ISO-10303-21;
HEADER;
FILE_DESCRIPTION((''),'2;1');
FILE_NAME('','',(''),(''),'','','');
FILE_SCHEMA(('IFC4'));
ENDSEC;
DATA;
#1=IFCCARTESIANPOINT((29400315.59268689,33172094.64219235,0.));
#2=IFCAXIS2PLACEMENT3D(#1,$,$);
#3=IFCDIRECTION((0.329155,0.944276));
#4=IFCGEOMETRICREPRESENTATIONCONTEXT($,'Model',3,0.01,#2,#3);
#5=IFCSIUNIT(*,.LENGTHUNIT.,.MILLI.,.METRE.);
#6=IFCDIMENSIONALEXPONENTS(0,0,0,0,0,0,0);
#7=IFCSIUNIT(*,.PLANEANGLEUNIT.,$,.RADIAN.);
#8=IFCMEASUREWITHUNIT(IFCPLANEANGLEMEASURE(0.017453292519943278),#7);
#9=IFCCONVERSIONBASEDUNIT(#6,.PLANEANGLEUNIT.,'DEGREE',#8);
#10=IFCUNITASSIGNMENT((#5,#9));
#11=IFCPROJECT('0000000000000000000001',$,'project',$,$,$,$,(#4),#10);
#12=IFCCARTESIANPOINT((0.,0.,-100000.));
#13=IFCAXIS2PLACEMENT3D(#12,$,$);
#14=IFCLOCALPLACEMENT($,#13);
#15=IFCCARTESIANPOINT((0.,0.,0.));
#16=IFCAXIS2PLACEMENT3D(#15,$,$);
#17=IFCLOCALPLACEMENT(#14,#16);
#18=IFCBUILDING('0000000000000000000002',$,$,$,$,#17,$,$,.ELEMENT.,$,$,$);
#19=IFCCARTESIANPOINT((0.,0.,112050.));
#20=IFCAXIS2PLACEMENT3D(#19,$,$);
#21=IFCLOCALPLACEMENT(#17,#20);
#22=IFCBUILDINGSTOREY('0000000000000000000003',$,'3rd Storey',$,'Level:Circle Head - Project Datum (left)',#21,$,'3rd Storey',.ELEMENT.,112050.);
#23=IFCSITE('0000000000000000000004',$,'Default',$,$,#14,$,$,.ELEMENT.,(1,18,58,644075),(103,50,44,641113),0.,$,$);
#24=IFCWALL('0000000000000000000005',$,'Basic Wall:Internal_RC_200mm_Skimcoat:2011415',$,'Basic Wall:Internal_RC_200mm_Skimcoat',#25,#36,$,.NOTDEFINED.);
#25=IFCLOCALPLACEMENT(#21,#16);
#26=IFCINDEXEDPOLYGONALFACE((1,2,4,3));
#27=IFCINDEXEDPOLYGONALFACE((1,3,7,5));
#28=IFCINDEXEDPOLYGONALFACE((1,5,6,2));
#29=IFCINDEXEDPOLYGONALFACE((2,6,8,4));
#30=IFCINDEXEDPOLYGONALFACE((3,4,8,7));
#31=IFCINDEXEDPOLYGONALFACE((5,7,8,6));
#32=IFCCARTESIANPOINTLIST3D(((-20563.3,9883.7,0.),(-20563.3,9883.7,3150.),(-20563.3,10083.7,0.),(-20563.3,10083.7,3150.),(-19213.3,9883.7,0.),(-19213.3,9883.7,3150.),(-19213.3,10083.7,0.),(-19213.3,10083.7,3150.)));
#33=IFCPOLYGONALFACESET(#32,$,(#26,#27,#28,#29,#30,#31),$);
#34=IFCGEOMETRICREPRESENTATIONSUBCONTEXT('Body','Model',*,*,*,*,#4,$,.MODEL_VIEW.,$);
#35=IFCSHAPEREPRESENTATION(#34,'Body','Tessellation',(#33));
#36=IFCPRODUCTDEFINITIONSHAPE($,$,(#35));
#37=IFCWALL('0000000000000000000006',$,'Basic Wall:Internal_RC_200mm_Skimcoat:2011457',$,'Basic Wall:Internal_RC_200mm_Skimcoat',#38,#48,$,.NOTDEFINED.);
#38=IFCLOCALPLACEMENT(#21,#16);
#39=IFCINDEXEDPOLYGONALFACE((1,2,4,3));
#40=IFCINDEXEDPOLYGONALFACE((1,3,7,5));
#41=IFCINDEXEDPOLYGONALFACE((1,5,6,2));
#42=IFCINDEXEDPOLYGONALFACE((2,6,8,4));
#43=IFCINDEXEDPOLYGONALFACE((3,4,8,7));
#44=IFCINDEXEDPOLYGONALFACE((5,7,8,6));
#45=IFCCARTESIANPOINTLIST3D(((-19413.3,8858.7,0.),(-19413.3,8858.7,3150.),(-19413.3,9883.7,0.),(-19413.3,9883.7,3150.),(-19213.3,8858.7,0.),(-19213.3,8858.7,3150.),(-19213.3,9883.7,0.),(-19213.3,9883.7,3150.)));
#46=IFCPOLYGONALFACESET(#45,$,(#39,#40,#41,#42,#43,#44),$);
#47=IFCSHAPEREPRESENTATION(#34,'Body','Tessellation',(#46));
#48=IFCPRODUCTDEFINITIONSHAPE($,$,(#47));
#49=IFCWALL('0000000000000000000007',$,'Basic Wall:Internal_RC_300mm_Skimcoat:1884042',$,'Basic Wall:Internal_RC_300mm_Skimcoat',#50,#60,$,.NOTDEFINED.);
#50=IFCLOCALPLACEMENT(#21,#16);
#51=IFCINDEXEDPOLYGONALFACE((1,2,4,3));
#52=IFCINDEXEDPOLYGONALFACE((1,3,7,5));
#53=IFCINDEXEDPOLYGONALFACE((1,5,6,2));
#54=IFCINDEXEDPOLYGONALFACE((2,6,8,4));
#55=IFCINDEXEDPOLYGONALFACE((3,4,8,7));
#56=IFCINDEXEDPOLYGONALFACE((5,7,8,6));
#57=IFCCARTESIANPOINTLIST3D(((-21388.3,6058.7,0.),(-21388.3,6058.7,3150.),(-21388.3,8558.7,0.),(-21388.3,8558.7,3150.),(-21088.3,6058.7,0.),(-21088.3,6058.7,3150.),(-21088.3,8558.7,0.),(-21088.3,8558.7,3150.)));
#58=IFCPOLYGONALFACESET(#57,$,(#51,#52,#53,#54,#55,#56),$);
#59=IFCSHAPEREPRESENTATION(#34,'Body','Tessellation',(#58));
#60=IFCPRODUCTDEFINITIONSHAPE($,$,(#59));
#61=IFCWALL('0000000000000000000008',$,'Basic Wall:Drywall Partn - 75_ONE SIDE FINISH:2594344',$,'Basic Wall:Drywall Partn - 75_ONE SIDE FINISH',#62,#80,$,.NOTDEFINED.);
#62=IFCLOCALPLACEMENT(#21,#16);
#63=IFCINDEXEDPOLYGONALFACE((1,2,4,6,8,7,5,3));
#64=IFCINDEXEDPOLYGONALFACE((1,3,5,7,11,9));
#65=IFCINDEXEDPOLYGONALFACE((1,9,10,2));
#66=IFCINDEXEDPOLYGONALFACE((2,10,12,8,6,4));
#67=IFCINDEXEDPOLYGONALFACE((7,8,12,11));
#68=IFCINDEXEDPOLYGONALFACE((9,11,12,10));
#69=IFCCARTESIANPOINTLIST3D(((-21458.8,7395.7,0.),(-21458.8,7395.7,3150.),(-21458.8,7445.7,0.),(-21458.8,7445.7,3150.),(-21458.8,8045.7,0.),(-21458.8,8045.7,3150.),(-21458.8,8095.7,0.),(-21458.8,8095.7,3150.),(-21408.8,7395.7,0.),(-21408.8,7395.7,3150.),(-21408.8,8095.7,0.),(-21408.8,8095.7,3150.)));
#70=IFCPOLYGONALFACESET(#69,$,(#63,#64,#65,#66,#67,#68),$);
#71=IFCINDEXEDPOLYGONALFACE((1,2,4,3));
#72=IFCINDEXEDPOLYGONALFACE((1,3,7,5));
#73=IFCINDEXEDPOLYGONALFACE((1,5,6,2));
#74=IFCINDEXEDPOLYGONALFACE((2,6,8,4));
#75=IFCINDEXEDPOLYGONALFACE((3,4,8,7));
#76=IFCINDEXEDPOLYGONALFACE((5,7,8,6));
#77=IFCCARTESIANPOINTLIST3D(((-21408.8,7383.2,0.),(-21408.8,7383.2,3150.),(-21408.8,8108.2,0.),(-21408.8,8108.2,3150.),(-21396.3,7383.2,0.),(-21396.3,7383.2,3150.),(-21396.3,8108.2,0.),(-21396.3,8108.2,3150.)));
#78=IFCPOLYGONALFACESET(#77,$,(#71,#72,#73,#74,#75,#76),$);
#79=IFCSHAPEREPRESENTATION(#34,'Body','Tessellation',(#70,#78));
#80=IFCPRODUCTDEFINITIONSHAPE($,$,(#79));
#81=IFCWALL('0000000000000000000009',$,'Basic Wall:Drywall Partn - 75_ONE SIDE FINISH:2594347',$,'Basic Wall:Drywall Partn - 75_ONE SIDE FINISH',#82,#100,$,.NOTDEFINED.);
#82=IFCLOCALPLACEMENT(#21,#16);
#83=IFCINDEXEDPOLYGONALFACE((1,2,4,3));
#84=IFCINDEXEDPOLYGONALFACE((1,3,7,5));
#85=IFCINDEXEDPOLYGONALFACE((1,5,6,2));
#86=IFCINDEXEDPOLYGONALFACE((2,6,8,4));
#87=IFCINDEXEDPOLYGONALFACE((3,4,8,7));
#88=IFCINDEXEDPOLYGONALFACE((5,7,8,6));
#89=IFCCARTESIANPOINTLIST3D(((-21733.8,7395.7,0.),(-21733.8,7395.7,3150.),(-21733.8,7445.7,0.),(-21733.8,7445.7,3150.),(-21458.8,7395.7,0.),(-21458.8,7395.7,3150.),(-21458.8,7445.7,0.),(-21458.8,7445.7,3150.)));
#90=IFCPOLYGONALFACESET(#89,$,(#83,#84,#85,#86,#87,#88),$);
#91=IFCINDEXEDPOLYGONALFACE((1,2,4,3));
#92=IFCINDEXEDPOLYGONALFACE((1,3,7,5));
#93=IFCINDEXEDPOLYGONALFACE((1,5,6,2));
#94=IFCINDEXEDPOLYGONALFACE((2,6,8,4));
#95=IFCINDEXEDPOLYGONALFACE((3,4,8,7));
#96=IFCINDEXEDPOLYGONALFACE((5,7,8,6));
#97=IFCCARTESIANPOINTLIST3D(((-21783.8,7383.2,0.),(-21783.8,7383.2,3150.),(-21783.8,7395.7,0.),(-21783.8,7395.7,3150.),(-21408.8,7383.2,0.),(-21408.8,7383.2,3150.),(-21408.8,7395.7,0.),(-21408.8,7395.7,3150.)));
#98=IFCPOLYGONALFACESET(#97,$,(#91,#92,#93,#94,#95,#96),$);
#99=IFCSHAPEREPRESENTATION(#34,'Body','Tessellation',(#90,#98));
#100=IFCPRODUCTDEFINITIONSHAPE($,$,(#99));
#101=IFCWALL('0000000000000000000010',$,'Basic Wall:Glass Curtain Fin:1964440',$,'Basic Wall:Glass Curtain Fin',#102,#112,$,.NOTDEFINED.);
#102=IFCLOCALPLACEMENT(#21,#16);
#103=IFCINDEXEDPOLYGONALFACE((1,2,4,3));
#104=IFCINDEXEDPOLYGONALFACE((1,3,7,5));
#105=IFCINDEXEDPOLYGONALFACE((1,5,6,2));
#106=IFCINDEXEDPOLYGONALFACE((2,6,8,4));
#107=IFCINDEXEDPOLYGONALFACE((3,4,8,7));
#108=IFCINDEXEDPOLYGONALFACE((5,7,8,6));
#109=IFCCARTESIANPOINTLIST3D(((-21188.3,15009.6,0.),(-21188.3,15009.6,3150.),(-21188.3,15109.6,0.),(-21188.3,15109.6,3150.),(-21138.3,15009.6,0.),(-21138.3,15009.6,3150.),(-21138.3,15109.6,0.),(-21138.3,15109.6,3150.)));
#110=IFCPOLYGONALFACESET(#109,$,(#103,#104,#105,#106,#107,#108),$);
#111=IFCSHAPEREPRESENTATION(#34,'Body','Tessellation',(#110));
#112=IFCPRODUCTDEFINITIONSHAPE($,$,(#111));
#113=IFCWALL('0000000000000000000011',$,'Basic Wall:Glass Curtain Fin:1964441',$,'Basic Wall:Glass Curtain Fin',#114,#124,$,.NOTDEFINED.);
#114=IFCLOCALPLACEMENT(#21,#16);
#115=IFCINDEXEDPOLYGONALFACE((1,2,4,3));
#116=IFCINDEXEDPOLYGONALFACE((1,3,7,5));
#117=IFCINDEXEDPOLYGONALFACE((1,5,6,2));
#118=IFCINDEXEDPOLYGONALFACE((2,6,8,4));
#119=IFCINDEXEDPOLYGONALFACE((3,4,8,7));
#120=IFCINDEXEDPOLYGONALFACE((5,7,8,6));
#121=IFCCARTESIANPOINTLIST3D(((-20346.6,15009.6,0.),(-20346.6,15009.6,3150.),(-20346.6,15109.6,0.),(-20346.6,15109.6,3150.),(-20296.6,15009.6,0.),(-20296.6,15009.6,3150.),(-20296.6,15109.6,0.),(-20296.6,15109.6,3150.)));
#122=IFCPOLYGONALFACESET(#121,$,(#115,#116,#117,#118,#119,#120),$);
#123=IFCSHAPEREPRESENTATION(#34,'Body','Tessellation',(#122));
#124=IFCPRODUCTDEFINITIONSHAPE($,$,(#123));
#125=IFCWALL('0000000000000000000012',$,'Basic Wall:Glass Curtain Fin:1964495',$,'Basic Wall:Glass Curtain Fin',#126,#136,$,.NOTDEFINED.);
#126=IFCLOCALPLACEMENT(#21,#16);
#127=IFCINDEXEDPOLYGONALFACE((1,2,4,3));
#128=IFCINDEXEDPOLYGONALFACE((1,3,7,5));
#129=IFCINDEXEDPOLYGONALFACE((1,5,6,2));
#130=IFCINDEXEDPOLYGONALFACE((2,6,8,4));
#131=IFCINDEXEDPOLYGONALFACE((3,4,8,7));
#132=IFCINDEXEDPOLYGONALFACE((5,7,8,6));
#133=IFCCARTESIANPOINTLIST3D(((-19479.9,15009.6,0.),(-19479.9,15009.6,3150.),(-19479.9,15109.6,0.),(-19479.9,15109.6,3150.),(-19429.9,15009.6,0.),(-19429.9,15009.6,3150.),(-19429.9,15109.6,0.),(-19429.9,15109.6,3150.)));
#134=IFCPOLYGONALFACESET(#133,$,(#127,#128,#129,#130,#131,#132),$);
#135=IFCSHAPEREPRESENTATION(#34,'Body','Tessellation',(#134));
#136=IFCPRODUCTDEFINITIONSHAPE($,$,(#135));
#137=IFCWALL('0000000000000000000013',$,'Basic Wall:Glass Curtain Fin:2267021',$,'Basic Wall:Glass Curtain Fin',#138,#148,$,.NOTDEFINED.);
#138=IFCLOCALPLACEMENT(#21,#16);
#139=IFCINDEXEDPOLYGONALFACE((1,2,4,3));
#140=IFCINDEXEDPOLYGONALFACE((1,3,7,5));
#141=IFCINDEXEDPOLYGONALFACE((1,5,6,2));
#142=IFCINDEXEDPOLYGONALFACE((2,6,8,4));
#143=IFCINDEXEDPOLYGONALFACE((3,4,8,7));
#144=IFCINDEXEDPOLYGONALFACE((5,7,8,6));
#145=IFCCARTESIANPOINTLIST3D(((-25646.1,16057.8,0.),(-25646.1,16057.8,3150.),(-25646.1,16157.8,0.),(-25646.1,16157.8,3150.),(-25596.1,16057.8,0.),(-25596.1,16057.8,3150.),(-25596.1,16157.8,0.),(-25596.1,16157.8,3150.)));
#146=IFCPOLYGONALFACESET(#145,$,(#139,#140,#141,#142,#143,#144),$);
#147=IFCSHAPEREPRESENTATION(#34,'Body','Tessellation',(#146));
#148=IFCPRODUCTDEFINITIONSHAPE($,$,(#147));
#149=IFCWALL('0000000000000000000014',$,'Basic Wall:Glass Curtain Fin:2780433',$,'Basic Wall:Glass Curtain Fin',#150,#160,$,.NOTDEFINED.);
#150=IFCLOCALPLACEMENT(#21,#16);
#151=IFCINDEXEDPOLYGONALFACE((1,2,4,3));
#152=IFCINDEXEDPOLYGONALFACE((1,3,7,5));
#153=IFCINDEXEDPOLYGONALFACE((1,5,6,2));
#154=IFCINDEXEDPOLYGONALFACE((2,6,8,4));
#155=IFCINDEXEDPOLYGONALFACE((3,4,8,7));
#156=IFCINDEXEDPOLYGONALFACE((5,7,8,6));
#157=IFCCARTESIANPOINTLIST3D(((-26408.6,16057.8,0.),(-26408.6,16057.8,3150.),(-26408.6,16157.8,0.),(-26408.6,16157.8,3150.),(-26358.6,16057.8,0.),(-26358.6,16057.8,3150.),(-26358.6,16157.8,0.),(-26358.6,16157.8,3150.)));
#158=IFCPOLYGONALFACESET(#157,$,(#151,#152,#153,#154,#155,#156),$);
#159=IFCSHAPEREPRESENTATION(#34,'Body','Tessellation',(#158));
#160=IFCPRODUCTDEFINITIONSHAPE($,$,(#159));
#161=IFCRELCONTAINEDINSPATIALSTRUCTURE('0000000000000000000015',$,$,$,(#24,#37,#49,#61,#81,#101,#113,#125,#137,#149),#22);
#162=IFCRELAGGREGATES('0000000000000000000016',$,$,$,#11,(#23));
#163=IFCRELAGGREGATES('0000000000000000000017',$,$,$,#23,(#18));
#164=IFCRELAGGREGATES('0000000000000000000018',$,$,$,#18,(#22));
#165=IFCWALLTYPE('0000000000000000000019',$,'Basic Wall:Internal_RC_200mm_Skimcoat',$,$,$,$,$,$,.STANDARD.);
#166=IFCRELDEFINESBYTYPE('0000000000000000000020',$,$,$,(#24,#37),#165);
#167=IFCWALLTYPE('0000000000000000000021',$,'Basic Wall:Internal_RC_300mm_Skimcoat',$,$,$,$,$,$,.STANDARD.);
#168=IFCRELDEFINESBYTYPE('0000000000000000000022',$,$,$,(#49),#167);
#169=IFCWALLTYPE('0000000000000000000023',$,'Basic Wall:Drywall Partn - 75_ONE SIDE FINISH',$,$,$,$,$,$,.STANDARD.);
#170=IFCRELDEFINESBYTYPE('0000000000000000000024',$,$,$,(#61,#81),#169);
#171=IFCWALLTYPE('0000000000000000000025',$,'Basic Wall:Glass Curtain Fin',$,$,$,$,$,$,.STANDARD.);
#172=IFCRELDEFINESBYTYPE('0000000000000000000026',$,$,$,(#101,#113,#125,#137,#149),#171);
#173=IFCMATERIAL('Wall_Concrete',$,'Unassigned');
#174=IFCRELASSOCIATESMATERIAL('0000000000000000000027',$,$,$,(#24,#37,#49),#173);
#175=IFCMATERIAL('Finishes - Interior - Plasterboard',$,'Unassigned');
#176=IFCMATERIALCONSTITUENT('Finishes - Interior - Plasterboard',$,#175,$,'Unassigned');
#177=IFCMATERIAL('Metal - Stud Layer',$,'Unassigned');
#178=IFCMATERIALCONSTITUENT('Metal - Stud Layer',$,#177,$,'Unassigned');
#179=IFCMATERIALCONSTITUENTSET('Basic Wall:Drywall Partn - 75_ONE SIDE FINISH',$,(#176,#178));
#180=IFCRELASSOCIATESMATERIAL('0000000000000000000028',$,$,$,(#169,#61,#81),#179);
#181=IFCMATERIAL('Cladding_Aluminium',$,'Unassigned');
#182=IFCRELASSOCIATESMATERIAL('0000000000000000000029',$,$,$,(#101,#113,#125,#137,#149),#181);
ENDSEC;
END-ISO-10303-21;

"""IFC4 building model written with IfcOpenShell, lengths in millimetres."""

from ifc_helpers import new_model, entity, si_unit, converted_unit, direction, frame, origin, place, context, subcontext, project, spatial, indexed_curve, outline, extrude, material, constituent, constituent_set, type_object, element, save


model = new_model("IFC4")

# Units and contexts
model_context = context("Model", 3, precision=0.01, world=frame((29400315.59268689, 33172094.64219235, 0.0)), true_north=direction((0.329155, 0.944276)))
body_context = subcontext(model_context, "Body", "Model", "MODEL_VIEW")
ifc_project = project(units=[si_unit("LENGTHUNIT", "METRE", prefix="MILLI"), converted_unit("PLANEANGLEUNIT", "DEGREE", entity("IfcPlaneAngleMeasure", 0.017453292519943278), si_unit("PLANEANGLEUNIT", "RADIAN"), dimensions=[0, 0, 0, 0, 0, 0, 0])], contexts=[model_context])

# Site, building, storey
site_placement = place(None, frame((0.0, 0.0, -100000.0)))
site = spatial("IfcSite", under=ifc_project, at=site_placement, Name="Default", CompositionType="ELEMENT", RefLatitude=(1, 18, 58, 644075), RefLongitude=(103, 50, 44, 641113), RefElevation=0.0)
building_placement = place(site_placement, origin())
building = spatial("IfcBuilding", under=site, at=building_placement, CompositionType="ELEMENT")
storey_placement = place(building_placement, frame((0.0, 0.0, 112050.0)))
storey = spatial("IfcBuildingStorey", under=building, at=storey_placement, Name="3rd Storey", ObjectType="Level:Circle Head - Project Datum (left)", LongName="3rd Storey", CompositionType="ELEMENT", Elevation=112050.0)

# Walls
ifc_material_1 = material(Name="Metal - Stud Layer", Category="Unassigned")
ifc_material_2 = material(Name="Wall_Concrete", Category="Unassigned")
wall_type_1 = type_object("IfcWallType", Name="Basic Wall:Internal_RC_200mm_Skimcoat", PredefinedType="STANDARD")
wall_1_placement = place(storey_placement, frame((-20563.3, 9983.7, 0.0)))
element("IfcWall", 1, at=wall_1_placement, inside=storey, type_object=wall_type_1, material=ifc_material_2, Name="Basic Wall:Internal_RC_200mm_Skimcoat:2011415", ObjectType="Basic Wall:Internal_RC_200mm_Skimcoat", PredefinedType="NOTDEFINED", context=body_context, shape_type="SweptSolid", body=[
    extrude(outline(indexed_curve([(1350.0, 100.0), (0.0, 100.0), (0.0, -100.0), (1350.0, -100.0), (1350.0, 100.0)], self_intersect=False)), origin(), (0.0, 0.0, 1.0), 3150.0),
])
wall_2_placement = place(storey_placement, frame((-19313.3, 9883.7, 0.0), z_axis=(0.0, 0.0, 1.0), x_axis=(0.0, -1.0, 0.0)))
element("IfcWall", 2, at=wall_2_placement, inside=storey, type_object=wall_type_1, material=ifc_material_2, Name="Basic Wall:Internal_RC_200mm_Skimcoat:2011457", ObjectType="Basic Wall:Internal_RC_200mm_Skimcoat", PredefinedType="NOTDEFINED", context=body_context, shape_type="SweptSolid", body=[
    extrude(outline(indexed_curve([(1025.0, 100.0), (0.0, 100.0), (0.0, -100.0), (1025.0, -100.0), (1025.0, 100.0)], self_intersect=False)), origin(), (0.0, 0.0, 1.0), 3150.0),
])
wall_type_2 = type_object("IfcWallType", Name="Basic Wall:Internal_RC_300mm_Skimcoat", PredefinedType="STANDARD")
wall_3_placement = place(storey_placement, frame((-21238.3, 8558.7, 0.0), z_axis=(0.0, 0.0, 1.0), x_axis=(0.0, -1.0, 0.0)))
element("IfcWall", 3, at=wall_3_placement, inside=storey, type_object=wall_type_2, material=ifc_material_2, Name="Basic Wall:Internal_RC_300mm_Skimcoat:1884042", ObjectType="Basic Wall:Internal_RC_300mm_Skimcoat", PredefinedType="NOTDEFINED", context=body_context, shape_type="SweptSolid", body=[
    extrude(outline(indexed_curve([(2500.0, 150.0), (0.0, 150.0), (0.0, -150.0), (2500.0, -150.0), (2500.0, 150.0)], self_intersect=False)), origin(), (0.0, 0.0, 1.0), 3150.0),
])
ifc_material_3 = material(Name="Finishes - Interior - Plasterboard", Category="Unassigned")
ifc_constituent_1 = constituent(ifc_material_3, Name="Finishes - Interior - Plasterboard", Category="Unassigned")
ifc_constituent_2 = constituent(ifc_material_1, Name="Metal - Stud Layer", Category="Unassigned")
ifc_constituent_set = constituent_set(constituents=[ifc_constituent_1, ifc_constituent_2], Name="Basic Wall:Drywall Partn - 75_ONE SIDE FINISH")
wall_type_3 = type_object("IfcWallType", Name="Basic Wall:Drywall Partn - 75_ONE SIDE FINISH", PredefinedType="STANDARD", material=ifc_constituent_set)
wall_4_placement = place(storey_placement, frame((-21427.6, 7383.2, 0.0), z_axis=(0.0, 0.0, 1.0), x_axis=(0.0, 1.0, 0.0)))
element("IfcWall", 4, at=wall_4_placement, inside=storey, type_object=wall_type_3, material=ifc_constituent_set, Name="Basic Wall:Drywall Partn - 75_ONE SIDE FINISH:2594344", ObjectType="Basic Wall:Drywall Partn - 75_ONE SIDE FINISH", PredefinedType="NOTDEFINED", context=body_context, shape_type="SweptSolid", body=[
    extrude(outline(indexed_curve([(-300.0, -16.7), (300.0, -16.7), (350.0, -16.7), (350.0, 33.3), (-350.0, 33.3), (-350.0, -16.7), (-300.0, -16.7)], self_intersect=False)), frame((362.5, 14.6, 0.0), z_axis=(0.0, 0.0, 1.0), x_axis=(-1.0, 0.0, 0.0)), (0.0, 0.0, 1.0), 3150.0),
    extrude(outline(indexed_curve([(-6.2, -362.5), (6.2, -362.5), (6.2, 362.5), (-6.3, 362.5), (-6.2, -362.5)], self_intersect=False)), frame((362.5, -25.0, 0.0), z_axis=(0.0, 0.0, 1.0), x_axis=(0.0, 1.0, 0.0)), (0.0, 0.0, 1.0), 3150.0),
])

# Walls
wall_5_placement = place(storey_placement, frame((-21458.8, 7414.5, 0.0), z_axis=(0.0, 0.0, 1.0), x_axis=(-1.0, 0.0, 0.0)))
element("IfcWall", 5, at=wall_5_placement, inside=storey, type_object=wall_type_3, material=ifc_constituent_set, Name="Basic Wall:Drywall Partn - 75_ONE SIDE FINISH:2594347", ObjectType="Basic Wall:Drywall Partn - 75_ONE SIDE FINISH", PredefinedType="NOTDEFINED", context=body_context, shape_type="SweptSolid", body=[
    extrude(outline(indexed_curve([(-25.0, -137.5), (25.0, -137.5), (25.0, 137.5), (-25.0, 137.5), (-25.0, -137.5)], self_intersect=False)), frame((137.5, -6.2, 0.0), z_axis=(0.0, 0.0, 1.0), x_axis=(0.0, 1.0, 0.0)), (0.0, 0.0, 1.0), 3150.0),
    extrude(outline(indexed_curve([(-6.2, -187.5), (6.3, -187.5), (6.2, 187.5), (-6.3, 187.5), (-6.2, -187.5)], self_intersect=False)), frame((137.5, 25.0, 0.0), z_axis=(0.0, 0.0, 1.0), x_axis=(0.0, -1.0, 0.0)), (0.0, 0.0, 1.0), 3150.0),
])
ifc_material_4 = material(Name="Cladding_Aluminium", Category="Unassigned")
wall_type_4 = type_object("IfcWallType", Name="Basic Wall:Glass Curtain Fin", PredefinedType="STANDARD")
for number, where, z_axis, x_axis, name in (
    (6, (-21163.3, 15009.6, 0.0), (0.0, 0.0, 1.0), (0.0, 1.0, 0.0), "Basic Wall:Glass Curtain Fin:1964440"),
    (7, (-20321.6, 15009.6, 0.0), (0.0, 0.0, 1.0), (0.0, 1.0, 0.0), "Basic Wall:Glass Curtain Fin:1964441"),
):
    element("IfcWall", number, at=place(storey_placement, frame(where, z_axis=z_axis, x_axis=x_axis)), inside=storey, type_object=wall_type_4, material=ifc_material_4, Name=name, ObjectType="Basic Wall:Glass Curtain Fin", PredefinedType="NOTDEFINED", context=body_context, shape_type="SweptSolid", body=[
        extrude(outline(indexed_curve([(100.0, 25.0), (0.0, 25.0), (0.0, -25.0), (100.0, -25.0), (100.0, 25.0)], self_intersect=False)), origin(), (0.0, 0.0, 1.0), 3150.0),
    ])
wall_6_placement = place(storey_placement, frame((-19454.9, 15009.6, 0.0), z_axis=(0.0, 0.0, 1.0), x_axis=(0.0, 1.0, 0.0)))
element("IfcWall", 8, at=wall_6_placement, inside=storey, type_object=wall_type_4, material=ifc_material_4, Name="Basic Wall:Glass Curtain Fin:1964495", ObjectType="Basic Wall:Glass Curtain Fin", PredefinedType="NOTDEFINED", context=body_context, shape_type="SweptSolid", body=[
    extrude(outline(indexed_curve([(100.0, 25.0), (0.0, 25.0), (0.0, -25.0), (100.0, -25.0), (100.0, 25.0)], self_intersect=False)), origin(), (0.0, 0.0, 1.0), 3150.0),
])
for number, where, z_axis, x_axis, name in (
    (9, (-25621.1, 16057.8, 0.0), (0.0, 0.0, 1.0), (0.0, 1.0, 0.0), "Basic Wall:Glass Curtain Fin:2267021"),
    (10, (-26383.6, 16057.8, 0.0), (0.0, 0.0, 1.0), (0.0, 1.0, 0.0), "Basic Wall:Glass Curtain Fin:2780433"),
):
    element("IfcWall", number, at=place(storey_placement, frame(where, z_axis=z_axis, x_axis=x_axis)), inside=storey, type_object=wall_type_4, material=ifc_material_4, Name=name, ObjectType="Basic Wall:Glass Curtain Fin", PredefinedType="NOTDEFINED", context=body_context, shape_type="SweptSolid", body=[
        extrude(outline(indexed_curve([(100.0, 25.0), (0.0, 25.0), (0.0, -25.0), (100.0, -25.0), (100.0, 25.0)], self_intersect=False)), origin(), (0.0, 0.0, 1.0), 3150.0),
    ])

save(model, "model.ifc")
